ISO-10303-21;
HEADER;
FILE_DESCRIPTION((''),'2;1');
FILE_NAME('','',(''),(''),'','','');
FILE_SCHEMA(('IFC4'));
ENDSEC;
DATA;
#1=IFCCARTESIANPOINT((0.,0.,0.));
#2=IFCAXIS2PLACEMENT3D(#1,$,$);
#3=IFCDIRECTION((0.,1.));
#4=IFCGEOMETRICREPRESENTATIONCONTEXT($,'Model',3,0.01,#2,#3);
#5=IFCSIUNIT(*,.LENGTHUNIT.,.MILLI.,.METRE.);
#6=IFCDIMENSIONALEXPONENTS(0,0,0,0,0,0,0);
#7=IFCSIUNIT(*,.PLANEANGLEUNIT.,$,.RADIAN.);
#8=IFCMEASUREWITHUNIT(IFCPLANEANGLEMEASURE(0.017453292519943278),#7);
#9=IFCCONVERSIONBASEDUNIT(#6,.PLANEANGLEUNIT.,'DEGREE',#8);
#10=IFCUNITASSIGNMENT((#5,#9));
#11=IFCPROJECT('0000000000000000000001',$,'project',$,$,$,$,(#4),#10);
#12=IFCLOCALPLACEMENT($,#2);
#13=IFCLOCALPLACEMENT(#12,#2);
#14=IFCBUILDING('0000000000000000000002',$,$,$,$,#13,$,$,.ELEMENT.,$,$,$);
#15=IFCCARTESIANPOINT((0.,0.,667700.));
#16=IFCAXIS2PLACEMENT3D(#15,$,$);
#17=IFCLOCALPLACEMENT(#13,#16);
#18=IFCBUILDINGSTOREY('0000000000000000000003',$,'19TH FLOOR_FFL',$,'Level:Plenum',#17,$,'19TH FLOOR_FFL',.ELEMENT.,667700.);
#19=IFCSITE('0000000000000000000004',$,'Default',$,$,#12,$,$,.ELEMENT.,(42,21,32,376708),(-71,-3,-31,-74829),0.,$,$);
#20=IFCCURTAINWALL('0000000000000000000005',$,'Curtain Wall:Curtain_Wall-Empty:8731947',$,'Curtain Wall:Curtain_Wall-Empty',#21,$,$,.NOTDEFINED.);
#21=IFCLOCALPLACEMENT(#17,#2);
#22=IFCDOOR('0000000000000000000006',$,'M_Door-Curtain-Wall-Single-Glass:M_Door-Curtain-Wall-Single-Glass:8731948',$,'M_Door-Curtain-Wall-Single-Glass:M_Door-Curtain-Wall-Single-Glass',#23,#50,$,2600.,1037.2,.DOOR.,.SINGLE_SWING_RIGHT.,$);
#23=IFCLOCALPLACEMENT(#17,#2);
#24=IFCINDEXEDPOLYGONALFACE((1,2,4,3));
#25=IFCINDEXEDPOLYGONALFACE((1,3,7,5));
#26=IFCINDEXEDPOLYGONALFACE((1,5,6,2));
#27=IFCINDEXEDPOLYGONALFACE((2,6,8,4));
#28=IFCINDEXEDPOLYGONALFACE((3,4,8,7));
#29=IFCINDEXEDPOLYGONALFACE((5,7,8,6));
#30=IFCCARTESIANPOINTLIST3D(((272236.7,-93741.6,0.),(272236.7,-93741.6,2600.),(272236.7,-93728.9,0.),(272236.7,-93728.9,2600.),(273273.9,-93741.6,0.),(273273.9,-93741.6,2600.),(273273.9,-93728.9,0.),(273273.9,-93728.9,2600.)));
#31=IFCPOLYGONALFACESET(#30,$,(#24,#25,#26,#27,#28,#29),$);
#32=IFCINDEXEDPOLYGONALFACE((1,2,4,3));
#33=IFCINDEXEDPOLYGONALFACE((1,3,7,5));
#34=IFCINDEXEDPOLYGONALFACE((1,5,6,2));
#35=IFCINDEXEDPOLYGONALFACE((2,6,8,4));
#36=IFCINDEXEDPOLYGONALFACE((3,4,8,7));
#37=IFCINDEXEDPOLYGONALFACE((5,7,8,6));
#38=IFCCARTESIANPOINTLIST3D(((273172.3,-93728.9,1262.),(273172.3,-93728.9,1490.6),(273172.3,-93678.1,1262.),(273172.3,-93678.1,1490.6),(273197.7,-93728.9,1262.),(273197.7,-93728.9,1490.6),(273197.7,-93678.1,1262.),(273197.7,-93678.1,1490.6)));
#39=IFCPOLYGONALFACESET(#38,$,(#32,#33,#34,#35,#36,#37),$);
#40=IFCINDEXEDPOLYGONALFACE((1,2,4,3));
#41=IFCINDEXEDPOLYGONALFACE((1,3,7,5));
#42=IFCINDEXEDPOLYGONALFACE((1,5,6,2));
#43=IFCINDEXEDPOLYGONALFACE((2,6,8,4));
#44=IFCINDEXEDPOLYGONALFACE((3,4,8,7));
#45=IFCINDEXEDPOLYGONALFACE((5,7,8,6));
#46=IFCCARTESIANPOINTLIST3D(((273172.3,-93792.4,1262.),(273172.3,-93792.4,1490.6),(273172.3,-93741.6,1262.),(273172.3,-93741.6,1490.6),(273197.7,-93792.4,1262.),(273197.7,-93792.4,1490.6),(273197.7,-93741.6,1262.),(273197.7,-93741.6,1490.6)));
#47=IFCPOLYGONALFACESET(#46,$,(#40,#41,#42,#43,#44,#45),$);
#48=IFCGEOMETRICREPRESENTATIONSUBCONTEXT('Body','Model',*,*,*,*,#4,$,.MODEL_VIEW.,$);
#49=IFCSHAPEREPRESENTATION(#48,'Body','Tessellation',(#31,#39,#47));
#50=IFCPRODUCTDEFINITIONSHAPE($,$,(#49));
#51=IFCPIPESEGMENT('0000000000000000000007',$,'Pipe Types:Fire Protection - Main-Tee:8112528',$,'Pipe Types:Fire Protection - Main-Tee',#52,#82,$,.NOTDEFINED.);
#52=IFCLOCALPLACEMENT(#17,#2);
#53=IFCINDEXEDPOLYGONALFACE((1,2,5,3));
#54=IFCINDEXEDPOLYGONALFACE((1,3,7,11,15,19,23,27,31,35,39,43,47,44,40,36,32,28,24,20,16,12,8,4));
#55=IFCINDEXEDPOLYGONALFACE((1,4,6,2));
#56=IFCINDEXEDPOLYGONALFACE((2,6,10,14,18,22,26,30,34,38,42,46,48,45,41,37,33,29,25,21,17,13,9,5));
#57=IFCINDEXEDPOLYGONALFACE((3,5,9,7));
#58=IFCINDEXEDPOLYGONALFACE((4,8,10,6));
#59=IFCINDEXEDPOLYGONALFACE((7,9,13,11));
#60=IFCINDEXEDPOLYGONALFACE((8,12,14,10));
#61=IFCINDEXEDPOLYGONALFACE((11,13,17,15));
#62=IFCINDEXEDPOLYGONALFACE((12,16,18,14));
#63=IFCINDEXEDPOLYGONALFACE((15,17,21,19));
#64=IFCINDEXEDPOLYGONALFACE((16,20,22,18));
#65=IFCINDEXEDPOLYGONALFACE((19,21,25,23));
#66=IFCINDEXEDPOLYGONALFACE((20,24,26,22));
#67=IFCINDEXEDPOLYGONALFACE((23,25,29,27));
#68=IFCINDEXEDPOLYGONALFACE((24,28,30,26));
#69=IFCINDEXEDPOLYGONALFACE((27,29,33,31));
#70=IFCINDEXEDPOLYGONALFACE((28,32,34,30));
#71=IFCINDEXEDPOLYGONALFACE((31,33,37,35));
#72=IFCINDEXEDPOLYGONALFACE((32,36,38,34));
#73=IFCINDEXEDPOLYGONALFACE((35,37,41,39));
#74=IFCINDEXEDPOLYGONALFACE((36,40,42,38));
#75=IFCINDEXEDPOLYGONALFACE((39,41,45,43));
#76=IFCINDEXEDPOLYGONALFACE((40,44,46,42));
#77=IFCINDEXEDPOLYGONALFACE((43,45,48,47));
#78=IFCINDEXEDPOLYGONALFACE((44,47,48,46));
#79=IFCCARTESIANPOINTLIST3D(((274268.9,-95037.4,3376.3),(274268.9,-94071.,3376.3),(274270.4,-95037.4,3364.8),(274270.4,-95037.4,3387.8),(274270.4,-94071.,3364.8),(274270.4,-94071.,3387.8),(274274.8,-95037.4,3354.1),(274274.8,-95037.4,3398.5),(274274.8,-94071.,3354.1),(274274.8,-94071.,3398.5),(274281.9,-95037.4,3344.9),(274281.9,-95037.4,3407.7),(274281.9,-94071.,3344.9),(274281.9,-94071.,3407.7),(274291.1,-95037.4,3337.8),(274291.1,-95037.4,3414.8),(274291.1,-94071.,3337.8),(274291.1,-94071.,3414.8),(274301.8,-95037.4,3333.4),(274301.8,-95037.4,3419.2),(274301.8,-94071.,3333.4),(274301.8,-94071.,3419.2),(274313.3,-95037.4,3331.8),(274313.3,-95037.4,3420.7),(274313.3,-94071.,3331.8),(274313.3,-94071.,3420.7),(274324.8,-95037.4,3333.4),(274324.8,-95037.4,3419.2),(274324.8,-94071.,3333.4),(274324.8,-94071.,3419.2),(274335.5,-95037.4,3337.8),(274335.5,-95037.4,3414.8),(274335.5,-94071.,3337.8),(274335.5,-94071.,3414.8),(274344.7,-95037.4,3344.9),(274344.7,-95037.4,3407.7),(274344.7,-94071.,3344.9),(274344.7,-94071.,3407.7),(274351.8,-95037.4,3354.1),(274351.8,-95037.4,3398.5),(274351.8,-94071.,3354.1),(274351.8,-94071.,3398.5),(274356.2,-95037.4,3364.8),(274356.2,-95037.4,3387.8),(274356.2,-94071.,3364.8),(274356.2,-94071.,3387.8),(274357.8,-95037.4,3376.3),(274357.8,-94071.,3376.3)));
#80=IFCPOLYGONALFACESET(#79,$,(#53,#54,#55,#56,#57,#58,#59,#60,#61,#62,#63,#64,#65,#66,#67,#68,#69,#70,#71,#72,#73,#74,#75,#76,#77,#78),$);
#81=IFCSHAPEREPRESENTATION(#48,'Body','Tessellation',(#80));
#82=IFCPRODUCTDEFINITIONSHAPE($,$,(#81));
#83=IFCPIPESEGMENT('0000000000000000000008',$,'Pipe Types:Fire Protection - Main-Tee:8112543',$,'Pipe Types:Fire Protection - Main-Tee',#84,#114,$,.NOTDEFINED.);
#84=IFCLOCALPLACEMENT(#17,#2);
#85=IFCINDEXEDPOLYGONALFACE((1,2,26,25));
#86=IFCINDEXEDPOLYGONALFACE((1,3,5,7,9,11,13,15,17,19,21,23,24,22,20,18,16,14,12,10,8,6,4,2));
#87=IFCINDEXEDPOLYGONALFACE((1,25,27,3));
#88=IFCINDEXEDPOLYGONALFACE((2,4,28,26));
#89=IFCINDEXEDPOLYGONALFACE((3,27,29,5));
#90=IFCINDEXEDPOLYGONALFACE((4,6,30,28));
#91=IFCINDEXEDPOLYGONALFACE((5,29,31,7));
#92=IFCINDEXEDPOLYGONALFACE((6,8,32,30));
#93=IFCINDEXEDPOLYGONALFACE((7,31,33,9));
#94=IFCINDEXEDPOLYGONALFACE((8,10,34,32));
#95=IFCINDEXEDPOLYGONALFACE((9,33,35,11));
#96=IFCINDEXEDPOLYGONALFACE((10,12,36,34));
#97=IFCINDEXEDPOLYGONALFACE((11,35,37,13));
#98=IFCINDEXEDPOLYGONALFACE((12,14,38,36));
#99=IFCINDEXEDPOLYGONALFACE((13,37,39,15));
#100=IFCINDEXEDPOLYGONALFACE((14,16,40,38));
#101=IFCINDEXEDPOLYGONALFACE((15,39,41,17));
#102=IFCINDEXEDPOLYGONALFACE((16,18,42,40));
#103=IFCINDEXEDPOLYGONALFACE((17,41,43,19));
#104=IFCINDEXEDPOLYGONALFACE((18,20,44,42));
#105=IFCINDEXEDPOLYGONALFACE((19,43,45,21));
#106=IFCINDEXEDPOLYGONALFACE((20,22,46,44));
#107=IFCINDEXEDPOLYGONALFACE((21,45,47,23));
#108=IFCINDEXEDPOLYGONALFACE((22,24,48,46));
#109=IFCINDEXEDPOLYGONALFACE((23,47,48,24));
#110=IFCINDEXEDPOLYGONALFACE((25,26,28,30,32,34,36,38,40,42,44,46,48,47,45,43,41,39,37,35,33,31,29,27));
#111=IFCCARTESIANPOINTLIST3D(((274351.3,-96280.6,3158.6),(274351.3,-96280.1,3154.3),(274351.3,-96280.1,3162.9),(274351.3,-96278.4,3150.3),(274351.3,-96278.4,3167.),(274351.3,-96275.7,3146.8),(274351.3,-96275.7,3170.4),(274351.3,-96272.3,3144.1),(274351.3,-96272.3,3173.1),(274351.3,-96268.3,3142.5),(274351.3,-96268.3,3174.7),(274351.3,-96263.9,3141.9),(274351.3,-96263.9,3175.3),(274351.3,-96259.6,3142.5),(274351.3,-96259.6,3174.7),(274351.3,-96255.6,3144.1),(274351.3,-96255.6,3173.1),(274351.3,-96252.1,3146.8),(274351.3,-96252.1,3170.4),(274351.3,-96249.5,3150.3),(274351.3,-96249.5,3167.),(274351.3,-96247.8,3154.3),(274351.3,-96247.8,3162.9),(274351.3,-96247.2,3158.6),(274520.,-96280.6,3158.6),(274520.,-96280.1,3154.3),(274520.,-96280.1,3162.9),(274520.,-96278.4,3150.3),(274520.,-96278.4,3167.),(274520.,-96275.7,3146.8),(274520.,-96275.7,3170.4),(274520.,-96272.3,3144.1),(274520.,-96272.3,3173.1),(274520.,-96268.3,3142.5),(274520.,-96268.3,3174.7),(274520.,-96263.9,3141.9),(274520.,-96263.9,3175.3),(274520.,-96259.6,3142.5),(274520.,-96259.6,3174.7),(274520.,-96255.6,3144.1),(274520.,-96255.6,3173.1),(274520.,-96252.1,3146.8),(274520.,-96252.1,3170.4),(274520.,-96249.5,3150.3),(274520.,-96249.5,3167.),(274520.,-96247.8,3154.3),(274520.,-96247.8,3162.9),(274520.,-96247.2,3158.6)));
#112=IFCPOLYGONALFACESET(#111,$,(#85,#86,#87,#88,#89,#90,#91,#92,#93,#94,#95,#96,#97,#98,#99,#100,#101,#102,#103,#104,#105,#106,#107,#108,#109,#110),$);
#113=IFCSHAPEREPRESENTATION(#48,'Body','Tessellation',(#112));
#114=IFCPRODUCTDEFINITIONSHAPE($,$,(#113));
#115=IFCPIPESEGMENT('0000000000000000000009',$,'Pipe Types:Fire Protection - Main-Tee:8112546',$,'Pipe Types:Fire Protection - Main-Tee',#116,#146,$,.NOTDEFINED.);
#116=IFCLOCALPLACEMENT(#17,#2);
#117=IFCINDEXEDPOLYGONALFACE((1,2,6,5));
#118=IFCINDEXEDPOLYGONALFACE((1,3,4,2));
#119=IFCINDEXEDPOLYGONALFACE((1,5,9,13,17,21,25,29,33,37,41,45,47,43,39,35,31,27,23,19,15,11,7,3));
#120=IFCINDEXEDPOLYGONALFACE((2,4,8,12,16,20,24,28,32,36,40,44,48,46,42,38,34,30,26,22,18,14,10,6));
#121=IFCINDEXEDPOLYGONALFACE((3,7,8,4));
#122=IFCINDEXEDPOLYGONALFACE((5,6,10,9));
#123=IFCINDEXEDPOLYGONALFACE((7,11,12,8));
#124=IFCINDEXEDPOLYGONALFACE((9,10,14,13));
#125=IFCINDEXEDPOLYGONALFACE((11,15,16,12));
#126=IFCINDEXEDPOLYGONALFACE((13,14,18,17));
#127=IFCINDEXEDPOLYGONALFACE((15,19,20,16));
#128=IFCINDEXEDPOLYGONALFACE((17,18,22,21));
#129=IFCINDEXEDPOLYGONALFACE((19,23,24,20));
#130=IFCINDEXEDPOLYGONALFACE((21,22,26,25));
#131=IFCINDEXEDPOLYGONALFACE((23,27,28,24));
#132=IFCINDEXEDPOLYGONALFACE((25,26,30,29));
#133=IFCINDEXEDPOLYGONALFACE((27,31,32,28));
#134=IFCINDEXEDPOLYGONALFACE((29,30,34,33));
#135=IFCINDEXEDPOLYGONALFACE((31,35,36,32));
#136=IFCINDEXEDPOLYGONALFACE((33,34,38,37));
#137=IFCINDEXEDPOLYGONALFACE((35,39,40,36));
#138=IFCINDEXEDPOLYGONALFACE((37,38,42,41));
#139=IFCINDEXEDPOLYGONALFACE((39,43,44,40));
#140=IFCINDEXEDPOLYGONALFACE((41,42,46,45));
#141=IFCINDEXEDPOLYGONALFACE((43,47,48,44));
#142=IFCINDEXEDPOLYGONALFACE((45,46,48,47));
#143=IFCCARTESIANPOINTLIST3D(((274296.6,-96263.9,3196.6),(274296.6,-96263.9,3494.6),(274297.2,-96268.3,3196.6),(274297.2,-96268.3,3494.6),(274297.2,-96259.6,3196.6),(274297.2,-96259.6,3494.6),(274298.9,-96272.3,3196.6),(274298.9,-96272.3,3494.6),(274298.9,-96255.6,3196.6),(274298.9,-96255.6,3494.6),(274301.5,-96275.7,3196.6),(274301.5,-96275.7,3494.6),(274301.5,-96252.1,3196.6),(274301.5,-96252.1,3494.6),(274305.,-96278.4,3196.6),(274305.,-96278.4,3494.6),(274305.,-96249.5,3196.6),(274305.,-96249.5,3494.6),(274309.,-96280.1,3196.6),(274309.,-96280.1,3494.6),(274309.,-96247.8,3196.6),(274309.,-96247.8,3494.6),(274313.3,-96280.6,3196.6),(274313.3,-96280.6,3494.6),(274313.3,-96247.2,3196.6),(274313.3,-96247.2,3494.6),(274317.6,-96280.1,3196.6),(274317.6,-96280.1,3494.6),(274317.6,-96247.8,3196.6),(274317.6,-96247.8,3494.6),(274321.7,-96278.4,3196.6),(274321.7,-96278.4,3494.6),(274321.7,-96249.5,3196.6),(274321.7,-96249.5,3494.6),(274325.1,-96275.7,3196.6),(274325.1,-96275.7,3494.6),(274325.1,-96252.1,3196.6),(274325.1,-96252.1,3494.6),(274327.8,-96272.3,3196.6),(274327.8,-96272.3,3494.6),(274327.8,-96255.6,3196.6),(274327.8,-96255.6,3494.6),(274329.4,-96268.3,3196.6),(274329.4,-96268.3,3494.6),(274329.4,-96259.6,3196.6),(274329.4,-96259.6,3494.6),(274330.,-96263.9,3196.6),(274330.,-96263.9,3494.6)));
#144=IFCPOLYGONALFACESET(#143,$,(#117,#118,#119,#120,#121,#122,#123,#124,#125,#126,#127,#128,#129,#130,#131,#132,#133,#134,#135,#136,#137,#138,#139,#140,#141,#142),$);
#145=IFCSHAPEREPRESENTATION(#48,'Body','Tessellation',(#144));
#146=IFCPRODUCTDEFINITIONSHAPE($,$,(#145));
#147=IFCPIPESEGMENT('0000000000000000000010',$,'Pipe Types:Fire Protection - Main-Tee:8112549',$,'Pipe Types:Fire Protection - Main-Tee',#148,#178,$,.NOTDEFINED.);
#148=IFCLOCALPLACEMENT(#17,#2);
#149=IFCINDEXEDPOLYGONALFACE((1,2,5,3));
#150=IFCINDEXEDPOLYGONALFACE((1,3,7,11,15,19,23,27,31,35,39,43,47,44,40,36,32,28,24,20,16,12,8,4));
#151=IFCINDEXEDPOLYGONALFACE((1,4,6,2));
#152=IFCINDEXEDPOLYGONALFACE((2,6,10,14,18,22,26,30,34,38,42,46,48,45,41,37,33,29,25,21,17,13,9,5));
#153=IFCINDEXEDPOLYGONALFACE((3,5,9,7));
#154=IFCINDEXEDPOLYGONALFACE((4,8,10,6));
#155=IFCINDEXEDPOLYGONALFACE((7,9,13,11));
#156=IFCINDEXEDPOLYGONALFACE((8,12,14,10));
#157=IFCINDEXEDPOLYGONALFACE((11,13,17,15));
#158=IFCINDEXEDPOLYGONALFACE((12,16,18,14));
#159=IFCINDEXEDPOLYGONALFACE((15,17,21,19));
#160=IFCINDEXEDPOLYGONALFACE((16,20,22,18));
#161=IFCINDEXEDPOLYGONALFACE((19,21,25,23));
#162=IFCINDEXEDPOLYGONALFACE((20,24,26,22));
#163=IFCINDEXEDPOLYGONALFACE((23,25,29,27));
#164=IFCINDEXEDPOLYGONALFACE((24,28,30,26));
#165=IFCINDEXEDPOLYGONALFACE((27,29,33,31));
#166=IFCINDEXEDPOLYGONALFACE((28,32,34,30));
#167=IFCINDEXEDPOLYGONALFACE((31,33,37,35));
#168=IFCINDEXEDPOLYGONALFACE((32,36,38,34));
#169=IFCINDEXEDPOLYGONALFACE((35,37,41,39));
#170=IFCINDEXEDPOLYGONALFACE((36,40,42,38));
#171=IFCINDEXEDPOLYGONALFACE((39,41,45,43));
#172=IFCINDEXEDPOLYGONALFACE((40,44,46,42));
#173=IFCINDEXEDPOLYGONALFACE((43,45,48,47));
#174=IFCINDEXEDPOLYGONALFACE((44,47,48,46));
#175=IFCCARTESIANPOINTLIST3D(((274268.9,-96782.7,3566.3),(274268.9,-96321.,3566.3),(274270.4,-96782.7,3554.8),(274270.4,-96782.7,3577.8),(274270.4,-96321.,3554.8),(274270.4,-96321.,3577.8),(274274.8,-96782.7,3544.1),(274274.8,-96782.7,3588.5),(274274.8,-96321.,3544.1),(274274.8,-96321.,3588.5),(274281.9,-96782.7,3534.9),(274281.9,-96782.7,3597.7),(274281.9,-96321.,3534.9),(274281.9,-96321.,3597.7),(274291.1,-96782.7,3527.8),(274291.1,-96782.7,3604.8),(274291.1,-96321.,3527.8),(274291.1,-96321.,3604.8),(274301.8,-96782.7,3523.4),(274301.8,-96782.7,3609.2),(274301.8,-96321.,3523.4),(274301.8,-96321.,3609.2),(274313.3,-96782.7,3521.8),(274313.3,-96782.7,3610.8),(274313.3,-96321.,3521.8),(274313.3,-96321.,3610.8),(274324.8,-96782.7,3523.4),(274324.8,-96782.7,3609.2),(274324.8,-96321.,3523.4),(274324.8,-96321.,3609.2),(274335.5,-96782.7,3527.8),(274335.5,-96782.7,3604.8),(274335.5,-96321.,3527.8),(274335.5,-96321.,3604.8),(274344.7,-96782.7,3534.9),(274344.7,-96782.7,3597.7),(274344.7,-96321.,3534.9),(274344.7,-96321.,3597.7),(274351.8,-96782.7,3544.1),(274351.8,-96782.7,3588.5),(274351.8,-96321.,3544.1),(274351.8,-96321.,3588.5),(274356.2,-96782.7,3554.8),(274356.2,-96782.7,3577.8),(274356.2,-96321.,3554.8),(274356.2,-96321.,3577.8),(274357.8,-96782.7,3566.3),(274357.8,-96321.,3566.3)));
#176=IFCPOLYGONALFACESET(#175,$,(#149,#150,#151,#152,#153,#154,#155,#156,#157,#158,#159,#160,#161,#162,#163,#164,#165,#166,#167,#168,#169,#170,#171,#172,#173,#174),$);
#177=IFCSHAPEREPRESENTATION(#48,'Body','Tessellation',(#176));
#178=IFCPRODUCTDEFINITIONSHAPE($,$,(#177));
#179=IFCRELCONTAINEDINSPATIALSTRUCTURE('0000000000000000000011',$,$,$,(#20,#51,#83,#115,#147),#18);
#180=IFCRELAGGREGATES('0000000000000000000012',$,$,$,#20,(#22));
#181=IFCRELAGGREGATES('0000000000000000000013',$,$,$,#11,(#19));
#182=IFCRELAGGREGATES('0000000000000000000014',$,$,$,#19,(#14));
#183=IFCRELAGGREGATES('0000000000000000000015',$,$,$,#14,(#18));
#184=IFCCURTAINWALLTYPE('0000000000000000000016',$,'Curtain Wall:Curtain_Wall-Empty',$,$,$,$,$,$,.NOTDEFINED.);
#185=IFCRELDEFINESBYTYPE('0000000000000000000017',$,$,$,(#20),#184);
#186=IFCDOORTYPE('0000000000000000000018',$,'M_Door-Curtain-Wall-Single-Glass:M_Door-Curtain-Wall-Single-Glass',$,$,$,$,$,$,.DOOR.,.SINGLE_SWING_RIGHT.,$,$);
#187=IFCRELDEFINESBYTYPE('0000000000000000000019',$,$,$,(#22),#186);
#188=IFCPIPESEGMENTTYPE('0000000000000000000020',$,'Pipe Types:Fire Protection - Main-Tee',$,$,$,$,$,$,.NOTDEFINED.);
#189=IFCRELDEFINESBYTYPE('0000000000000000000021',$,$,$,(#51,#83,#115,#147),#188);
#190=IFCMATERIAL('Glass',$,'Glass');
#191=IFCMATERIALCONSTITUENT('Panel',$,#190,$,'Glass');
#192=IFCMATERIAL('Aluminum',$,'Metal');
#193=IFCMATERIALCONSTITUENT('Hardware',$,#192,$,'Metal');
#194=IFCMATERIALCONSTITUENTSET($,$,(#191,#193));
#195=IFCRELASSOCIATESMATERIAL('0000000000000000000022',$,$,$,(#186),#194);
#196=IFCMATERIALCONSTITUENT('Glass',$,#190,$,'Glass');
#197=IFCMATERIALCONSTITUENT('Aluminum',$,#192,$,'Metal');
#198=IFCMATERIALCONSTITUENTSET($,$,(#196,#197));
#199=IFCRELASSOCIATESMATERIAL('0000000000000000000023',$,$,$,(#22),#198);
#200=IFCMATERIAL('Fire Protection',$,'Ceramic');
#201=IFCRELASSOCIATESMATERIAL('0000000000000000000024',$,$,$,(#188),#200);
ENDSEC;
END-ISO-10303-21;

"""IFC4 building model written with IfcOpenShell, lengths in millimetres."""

from ifc_helpers import new_model, entity, si_unit, converted_unit, direction, frame, origin, place, context, subcontext, project, spatial, arc, indexed_curve, outline, extrude, source, transform, mapped, material, constituent, constituent_set, type_object, type_shapes, element, aggregate, save


model = new_model("IFC4")

# Units and contexts
model_context = context("Model", 3, precision=0.01, world=origin(), true_north=direction((0.0, 1.0)))
body_context = subcontext(model_context, "Body", "Model", "MODEL_VIEW")
ifc_project = project(units=[si_unit("LENGTHUNIT", "METRE", prefix="MILLI"), converted_unit("PLANEANGLEUNIT", "DEGREE", entity("IfcPlaneAngleMeasure", 0.017453292519943278), si_unit("PLANEANGLEUNIT", "RADIAN"), dimensions=[0, 0, 0, 0, 0, 0, 0])], contexts=[model_context])

# Site, building, storey
site_placement = place(None, origin())
site = spatial("IfcSite", under=ifc_project, at=site_placement, Name="Default", CompositionType="ELEMENT", RefLatitude=(42, 21, 32, 376708), RefLongitude=(-71, -3, -31, -74829), RefElevation=0.0)
building_placement = place(site_placement, origin())
building = spatial("IfcBuilding", under=site, at=building_placement, CompositionType="ELEMENT")
storey_placement = place(building_placement, frame((0.0, 0.0, 667700.0)))
storey = spatial("IfcBuildingStorey", under=building, at=storey_placement, Name="19TH FLOOR_FFL", ObjectType="Level:Plenum", LongName="19TH FLOOR_FFL", CompositionType="ELEMENT", Elevation=667700.0)

# Curtain wall
curtain_wall_type = type_object("IfcCurtainWallType", Name="Curtain Wall:Curtain_Wall-Empty", PredefinedType="NOTDEFINED")
curtain_wall_1_placement = place(storey_placement, frame((0.0, 0.0, -667700.0)))
curtain_wall_1 = element("IfcCurtainWall", 1, at=curtain_wall_1_placement, inside=storey, type_object=curtain_wall_type, Name="Curtain Wall:Curtain_Wall-Empty:8731947", ObjectType="Curtain Wall:Curtain_Wall-Empty", PredefinedType="NOTDEFINED")

# Door
ifc_material_1 = material(Name="Glass", Category="Glass")
ifc_material_2 = material(Name="Aluminum", Category="Metal")
ifc_constituent_1 = constituent(ifc_material_1, Name="Glass", Category="Glass")
ifc_constituent_2 = constituent(ifc_material_2, Name="Aluminum", Category="Metal")
ifc_constituent_set_1 = constituent_set(constituents=[ifc_constituent_1, ifc_constituent_2])
ifc_constituent_3 = constituent(ifc_material_1, Name="Panel", Category="Glass")
ifc_constituent_4 = constituent(ifc_material_2, Name="Hardware", Category="Metal")
ifc_constituent_set_2 = constituent_set(constituents=[ifc_constituent_3, ifc_constituent_4])
door_type_1 = type_object("IfcDoorType", Name="M_Door-Curtain-Wall-Single-Glass:M_Door-Curtain-Wall-Single-Glass", OperationType="SINGLE_SWING_RIGHT", PredefinedType="DOOR", material=ifc_constituent_set_2)
shared_shape_1 = source(origin(), body_context, "Body", "SweptSolid", [
    extrude(outline(indexed_curve([(-518.6, -6.4), (518.6, -6.4), (518.6, 6.4), (-518.6, 6.4), (-518.6, -6.4)], self_intersect=False)), frame((0.0, -6.3, 0.0), z_axis=(0.0, 0.0, 1.0), x_axis=(-1.0, 0.0, 0.0)), (0.0, 0.0, 1.0), 2600.0),
    extrude(outline(indexed_curve([(-25.4, -12.7), (25.4, -12.7), (25.4, 12.7), (-25.4, 12.7), (-25.4, -12.7)], self_intersect=False)), frame((-429.7, -38.1, 1262.0), z_axis=(0.0, 0.0, 1.0), x_axis=(0.0, 1.0, 0.0)), (0.0, 0.0, 1.0), 228.6),
    extrude(outline(indexed_curve([(-25.4, -12.7), (25.4, -12.7), (25.4, 12.7), (-25.4, 12.7), (-25.4, -12.7)], self_intersect=False)), frame((-429.7, 25.4, 1262.0), z_axis=(0.0, 0.0, 1.0), x_axis=(0.0, -1.0, 0.0)), (0.0, 0.0, 1.0), 228.6),
])
type_shapes(door_type_1, [shared_shape_1])
door_1_placement = place(curtain_wall_1_placement, frame((272755.3, -93741.6, 667700.0), z_axis=(0.0, 0.0, 1.0), x_axis=(-1.0, 0.0, 0.0)))
door_1 = element("IfcDoor", 2, at=door_1_placement, type_object=door_type_1, material=ifc_constituent_set_1, Name="M_Door-Curtain-Wall-Single-Glass:M_Door-Curtain-Wall-Single-Glass:8731948", ObjectType="M_Door-Curtain-Wall-Single-Glass:M_Door-Curtain-Wall-Single-Glass", OperationType="SINGLE_SWING_RIGHT", OverallHeight=2600.0, OverallWidth=1037.2, PredefinedType="DOOR", context=body_context, shape_type="MappedRepresentation", body=[
    mapped(shared_shape_1, transform((0.0, 0.0, 0.0), scale=1.0)),
])
aggregate(curtain_wall_1, [door_1])

# Pipe segments
ifc_material_3 = material(Name="Fire Protection", Category="Ceramic")
pipe_segment_type = type_object("IfcPipeSegmentType", Name="Pipe Types:Fire Protection - Main-Tee", PredefinedType="NOTDEFINED", material=ifc_material_3)
pipe_segment_1_placement = place(storey_placement, origin())
element("IfcPipeSegment", 3, at=pipe_segment_1_placement, inside=storey, type_object=pipe_segment_type, Name="Pipe Types:Fire Protection - Main-Tee:8112528", ObjectType="Pipe Types:Fire Protection - Main-Tee", PredefinedType="NOTDEFINED", context=body_context, shape_type="SweptSolid", body=[
    extrude(outline(indexed_curve([(44.5, 0.0), (31.4, 31.4), (0.0, 44.5), (-31.4, 31.4), (-44.4, 0.0), (-31.4, -31.4), (0.0, -44.5), (31.4, -31.4)], segments=[arc(1, 2, 3), arc(3, 4, 5), arc(5, 6, 7), arc(7, 8, 1)], self_intersect=False)), frame((274313.3, -95037.4, 3376.3), z_axis=(0.0, 1.0, 0.0), x_axis=(1.0, 0.0, 0.0)), (0.0, 0.0, 1.0), 966.3),
])
pipe_segment_2_placement = place(storey_placement, origin())
element("IfcPipeSegment", 4, at=pipe_segment_2_placement, inside=storey, type_object=pipe_segment_type, Name="Pipe Types:Fire Protection - Main-Tee:8112543", ObjectType="Pipe Types:Fire Protection - Main-Tee", PredefinedType="NOTDEFINED", context=body_context, shape_type="SweptSolid", body=[
    extrude(outline(indexed_curve([(16.7, 0.0), (11.8, 11.8), (0.0, 16.7), (-11.8, 11.8), (-16.7, 0.0), (-11.8, -11.8), (0.0, -16.7), (11.8, -11.8)], segments=[arc(1, 2, 3), arc(3, 4, 5), arc(5, 6, 7), arc(7, 8, 1)], self_intersect=False)), frame((274351.3, -96263.9, 3158.6), z_axis=(1.0, 0.0, 0.0), x_axis=(0.0, 1.0, 0.0)), (0.0, 0.0, 1.0), 168.7),
])
pipe_segment_3_placement = place(storey_placement, origin())
element("IfcPipeSegment", 5, at=pipe_segment_3_placement, inside=storey, type_object=pipe_segment_type, Name="Pipe Types:Fire Protection - Main-Tee:8112546", ObjectType="Pipe Types:Fire Protection - Main-Tee", PredefinedType="NOTDEFINED", context=body_context, shape_type="SweptSolid", body=[
    extrude(outline(indexed_curve([(16.7, 0.0), (11.8, 11.8), (0.0, 16.7), (-11.8, 11.8), (-16.7, 0.0), (-11.8, -11.8), (0.0, -16.7), (11.8, -11.8)], segments=[arc(1, 2, 3), arc(3, 4, 5), arc(5, 6, 7), arc(7, 8, 1)], self_intersect=False)), frame((274313.3, -96263.9, 3196.6)), (0.0, 0.0, 1.0), 298.0),
])
pipe_segment_4_placement = place(storey_placement, origin())
element("IfcPipeSegment", 6, at=pipe_segment_4_placement, inside=storey, type_object=pipe_segment_type, Name="Pipe Types:Fire Protection - Main-Tee:8112549", ObjectType="Pipe Types:Fire Protection - Main-Tee", PredefinedType="NOTDEFINED", context=body_context, shape_type="SweptSolid", body=[
    extrude(outline(indexed_curve([(44.5, 0.0), (31.4, 31.4), (0.0, 44.5), (-31.4, 31.4), (-44.4, 0.0), (-31.4, -31.4), (0.0, -44.5), (31.4, -31.4)], segments=[arc(1, 2, 3), arc(3, 4, 5), arc(5, 6, 7), arc(7, 8, 1)], self_intersect=False)), frame((274313.3, -96782.7, 3566.3), z_axis=(0.0, 1.0, 0.0), x_axis=(1.0, 0.0, 0.0)), (0.0, 0.0, 1.0), 461.6),
])

save(model, "model.ifc")
